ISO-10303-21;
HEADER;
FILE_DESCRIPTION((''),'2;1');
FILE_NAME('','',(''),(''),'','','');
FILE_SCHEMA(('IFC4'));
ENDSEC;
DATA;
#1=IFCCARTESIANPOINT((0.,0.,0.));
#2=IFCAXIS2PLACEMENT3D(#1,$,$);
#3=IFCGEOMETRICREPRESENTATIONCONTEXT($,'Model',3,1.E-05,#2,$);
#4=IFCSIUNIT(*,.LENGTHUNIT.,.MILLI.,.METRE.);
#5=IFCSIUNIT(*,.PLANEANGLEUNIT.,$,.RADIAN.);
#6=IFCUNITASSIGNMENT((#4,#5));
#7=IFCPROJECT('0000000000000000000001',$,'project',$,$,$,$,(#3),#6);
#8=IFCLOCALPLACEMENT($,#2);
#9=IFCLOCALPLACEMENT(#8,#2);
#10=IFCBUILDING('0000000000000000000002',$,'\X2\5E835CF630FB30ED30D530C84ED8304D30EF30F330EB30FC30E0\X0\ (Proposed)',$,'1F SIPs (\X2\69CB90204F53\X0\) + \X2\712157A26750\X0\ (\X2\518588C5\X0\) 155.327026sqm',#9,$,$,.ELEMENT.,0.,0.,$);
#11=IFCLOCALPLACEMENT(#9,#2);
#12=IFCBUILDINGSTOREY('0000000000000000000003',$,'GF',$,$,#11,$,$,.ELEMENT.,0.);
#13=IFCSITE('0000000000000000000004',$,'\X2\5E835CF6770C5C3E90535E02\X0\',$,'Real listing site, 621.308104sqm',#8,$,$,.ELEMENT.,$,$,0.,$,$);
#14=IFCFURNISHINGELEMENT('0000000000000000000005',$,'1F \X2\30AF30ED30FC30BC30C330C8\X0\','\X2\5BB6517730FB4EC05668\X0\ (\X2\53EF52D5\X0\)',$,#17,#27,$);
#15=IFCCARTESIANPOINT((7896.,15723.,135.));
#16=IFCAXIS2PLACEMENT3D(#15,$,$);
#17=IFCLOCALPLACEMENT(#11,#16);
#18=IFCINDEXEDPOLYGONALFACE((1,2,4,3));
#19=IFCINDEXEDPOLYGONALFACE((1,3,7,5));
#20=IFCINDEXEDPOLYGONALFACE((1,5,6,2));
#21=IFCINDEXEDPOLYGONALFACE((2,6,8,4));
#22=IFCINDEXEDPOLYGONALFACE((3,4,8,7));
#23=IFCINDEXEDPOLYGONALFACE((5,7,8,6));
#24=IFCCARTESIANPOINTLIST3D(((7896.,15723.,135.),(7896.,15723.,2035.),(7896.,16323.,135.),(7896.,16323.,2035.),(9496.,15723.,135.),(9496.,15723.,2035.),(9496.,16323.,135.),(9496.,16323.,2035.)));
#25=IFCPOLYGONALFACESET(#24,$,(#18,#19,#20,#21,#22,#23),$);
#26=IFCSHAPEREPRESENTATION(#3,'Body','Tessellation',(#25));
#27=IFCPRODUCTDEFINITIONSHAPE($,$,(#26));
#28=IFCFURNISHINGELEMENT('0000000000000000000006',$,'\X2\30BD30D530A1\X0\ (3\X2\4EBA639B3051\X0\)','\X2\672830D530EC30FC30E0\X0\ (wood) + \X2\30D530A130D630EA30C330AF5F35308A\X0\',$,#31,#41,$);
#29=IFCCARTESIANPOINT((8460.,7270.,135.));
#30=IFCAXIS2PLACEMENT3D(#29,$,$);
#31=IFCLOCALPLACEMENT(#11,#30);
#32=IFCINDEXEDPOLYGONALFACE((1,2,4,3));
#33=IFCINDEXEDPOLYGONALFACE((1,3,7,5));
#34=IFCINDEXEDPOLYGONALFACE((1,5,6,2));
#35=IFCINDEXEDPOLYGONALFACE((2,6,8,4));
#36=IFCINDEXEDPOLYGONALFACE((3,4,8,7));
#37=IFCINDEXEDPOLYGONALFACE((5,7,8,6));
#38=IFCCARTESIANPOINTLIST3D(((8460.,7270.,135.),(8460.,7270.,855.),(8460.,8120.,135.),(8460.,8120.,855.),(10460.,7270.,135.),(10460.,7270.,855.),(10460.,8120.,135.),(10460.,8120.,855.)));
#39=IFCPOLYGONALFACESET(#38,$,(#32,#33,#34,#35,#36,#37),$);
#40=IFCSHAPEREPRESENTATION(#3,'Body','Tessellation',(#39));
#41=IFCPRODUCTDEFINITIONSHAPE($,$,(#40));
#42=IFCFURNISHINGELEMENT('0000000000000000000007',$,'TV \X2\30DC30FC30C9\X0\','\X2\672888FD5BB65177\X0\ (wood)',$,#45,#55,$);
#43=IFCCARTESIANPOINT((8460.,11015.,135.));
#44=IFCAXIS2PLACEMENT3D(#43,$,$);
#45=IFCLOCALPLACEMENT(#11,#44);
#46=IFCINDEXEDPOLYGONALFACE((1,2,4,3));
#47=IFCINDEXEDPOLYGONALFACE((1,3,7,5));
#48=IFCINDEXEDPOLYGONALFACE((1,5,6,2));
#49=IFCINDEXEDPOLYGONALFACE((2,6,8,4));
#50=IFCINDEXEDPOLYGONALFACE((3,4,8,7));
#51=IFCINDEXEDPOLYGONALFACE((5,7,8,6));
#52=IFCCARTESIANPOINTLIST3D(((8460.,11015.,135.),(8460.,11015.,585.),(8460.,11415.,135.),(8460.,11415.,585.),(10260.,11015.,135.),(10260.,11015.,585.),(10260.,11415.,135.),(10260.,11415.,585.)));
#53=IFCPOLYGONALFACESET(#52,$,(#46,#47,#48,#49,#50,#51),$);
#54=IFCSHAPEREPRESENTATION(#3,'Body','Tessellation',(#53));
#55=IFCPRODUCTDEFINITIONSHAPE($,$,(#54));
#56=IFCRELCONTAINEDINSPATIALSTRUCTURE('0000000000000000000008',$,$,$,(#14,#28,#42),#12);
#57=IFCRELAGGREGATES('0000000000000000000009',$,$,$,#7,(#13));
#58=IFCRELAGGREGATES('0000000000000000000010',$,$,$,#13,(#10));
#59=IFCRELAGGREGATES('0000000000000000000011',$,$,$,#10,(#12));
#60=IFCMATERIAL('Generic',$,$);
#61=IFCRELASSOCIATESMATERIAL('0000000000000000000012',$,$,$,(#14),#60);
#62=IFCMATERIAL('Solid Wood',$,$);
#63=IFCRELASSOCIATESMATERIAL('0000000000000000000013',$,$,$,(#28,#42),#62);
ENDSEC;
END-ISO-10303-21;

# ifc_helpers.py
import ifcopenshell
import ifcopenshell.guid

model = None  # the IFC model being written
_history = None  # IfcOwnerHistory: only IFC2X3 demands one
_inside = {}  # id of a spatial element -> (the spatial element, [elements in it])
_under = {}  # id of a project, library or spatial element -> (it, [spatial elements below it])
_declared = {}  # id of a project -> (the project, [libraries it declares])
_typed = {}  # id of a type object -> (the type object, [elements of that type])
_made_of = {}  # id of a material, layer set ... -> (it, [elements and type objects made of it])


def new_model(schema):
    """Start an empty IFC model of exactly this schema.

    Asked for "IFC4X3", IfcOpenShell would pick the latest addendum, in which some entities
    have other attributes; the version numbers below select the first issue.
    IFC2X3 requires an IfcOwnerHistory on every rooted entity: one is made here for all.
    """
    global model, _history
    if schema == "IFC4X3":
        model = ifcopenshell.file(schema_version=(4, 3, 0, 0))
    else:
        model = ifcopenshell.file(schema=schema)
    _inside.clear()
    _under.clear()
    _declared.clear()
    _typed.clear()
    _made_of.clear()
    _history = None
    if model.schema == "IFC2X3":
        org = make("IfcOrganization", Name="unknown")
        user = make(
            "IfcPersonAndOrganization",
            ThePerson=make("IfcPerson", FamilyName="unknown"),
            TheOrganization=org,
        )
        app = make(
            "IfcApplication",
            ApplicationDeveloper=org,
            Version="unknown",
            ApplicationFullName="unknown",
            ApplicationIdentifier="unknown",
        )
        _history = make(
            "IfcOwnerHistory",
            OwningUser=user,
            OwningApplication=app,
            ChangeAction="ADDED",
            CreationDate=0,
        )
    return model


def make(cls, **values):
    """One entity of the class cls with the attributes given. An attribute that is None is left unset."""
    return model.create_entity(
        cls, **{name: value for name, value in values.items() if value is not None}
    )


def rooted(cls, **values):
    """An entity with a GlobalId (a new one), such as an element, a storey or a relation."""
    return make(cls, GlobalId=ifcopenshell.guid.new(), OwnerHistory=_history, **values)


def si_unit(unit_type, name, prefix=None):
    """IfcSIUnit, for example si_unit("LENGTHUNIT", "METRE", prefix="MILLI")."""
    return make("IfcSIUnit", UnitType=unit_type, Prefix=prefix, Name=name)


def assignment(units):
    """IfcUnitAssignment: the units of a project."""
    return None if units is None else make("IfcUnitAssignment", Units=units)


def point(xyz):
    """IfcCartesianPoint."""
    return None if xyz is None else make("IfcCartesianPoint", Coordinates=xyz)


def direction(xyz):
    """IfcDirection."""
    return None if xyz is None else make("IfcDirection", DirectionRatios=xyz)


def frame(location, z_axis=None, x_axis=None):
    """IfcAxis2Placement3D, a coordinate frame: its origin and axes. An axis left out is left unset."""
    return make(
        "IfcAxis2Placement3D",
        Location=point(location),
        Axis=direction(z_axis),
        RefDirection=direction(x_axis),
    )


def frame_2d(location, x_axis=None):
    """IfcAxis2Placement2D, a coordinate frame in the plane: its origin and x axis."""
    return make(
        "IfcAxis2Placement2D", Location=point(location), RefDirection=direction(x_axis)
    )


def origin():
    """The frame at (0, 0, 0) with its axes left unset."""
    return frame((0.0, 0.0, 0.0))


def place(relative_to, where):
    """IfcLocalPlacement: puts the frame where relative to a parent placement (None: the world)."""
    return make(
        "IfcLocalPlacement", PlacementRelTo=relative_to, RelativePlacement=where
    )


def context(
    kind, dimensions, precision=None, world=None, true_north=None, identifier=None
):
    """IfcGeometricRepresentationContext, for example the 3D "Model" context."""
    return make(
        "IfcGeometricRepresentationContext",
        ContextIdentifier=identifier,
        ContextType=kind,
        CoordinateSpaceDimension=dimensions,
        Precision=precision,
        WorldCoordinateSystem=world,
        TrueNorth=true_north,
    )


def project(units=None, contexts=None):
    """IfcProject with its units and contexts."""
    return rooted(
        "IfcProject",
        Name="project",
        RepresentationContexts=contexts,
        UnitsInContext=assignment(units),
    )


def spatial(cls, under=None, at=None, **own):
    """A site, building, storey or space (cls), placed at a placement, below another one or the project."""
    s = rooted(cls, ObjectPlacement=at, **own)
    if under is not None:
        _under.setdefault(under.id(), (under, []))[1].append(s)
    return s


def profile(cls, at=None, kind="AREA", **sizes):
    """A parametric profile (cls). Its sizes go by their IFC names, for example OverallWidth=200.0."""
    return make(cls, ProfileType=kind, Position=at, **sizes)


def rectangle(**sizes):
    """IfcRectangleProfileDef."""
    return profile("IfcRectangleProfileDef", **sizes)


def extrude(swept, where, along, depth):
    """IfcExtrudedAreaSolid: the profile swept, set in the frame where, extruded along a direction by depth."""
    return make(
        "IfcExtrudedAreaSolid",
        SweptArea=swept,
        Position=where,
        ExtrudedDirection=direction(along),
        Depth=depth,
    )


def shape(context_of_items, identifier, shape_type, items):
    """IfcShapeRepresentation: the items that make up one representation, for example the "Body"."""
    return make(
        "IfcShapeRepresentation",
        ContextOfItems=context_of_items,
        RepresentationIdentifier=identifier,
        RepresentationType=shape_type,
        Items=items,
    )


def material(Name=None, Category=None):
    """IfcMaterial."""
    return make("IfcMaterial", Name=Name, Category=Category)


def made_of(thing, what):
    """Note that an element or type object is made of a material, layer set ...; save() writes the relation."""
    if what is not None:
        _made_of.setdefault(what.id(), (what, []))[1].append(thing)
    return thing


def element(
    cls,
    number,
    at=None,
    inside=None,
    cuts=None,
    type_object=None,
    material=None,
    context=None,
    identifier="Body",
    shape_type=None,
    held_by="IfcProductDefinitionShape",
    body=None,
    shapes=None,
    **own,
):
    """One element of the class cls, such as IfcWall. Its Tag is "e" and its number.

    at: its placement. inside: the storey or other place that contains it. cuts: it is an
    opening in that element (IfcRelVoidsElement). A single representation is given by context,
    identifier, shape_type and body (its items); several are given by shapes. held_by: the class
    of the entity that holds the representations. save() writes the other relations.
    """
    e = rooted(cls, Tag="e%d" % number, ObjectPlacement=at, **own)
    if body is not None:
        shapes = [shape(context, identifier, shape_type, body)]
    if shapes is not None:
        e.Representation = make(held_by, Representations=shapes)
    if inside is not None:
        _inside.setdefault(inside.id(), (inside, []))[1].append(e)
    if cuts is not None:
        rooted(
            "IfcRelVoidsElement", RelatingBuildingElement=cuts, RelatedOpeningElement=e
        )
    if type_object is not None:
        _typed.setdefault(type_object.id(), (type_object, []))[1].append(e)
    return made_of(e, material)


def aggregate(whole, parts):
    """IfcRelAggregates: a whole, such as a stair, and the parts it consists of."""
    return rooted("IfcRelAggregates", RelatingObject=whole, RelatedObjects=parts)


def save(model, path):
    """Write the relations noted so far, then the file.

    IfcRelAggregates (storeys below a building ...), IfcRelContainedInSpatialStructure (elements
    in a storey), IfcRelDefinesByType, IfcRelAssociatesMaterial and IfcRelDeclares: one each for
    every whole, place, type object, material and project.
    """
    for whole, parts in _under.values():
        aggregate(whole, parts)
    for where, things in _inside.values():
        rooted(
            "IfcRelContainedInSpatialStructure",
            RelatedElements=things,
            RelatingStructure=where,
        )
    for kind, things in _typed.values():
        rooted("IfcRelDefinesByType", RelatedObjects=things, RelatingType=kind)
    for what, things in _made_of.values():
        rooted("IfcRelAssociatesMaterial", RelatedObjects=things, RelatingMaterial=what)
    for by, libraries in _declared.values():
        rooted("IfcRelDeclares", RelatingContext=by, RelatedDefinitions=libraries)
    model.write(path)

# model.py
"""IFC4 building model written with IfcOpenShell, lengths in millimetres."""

from ifc_helpers import new_model, si_unit, frame, frame_2d, origin, place, context, project, spatial, rectangle, extrude, material, element, save


model = new_model("IFC4")

# Units and contexts
model_context = context("Model", 3, precision=1e-05, world=origin())
ifc_project = project(units=[si_unit("LENGTHUNIT", "METRE", prefix="MILLI"), si_unit("PLANEANGLEUNIT", "RADIAN")], contexts=[model_context])

# Site, building, storey
site_placement = place(None, origin())
site = spatial("IfcSite", under=ifc_project, at=site_placement, Name="広島県尾道市", ObjectType="Real listing site, 621.308104sqm", CompositionType="ELEMENT", RefElevation=0.0)
building_placement = place(site_placement, origin())
building = spatial("IfcBuilding", under=site, at=building_placement, Name="広島・ロフト付きワンルーム (Proposed)", ObjectType="1F SIPs (構造体) + 無垢材 (内装) 155.327026sqm", CompositionType="ELEMENT", ElevationOfRefHeight=0.0, ElevationOfTerrain=0.0)
storey_placement = place(building_placement, origin())
storey = spatial("IfcBuildingStorey", under=building, at=storey_placement, Name="GF", CompositionType="ELEMENT", Elevation=0.0)

# Shared definitions
ifc_material_1 = material(Name="Solid Wood")

# Shared definitions
ifc_material_2 = material(Name="Generic")

# Furnishing elements
furnishing_1_placement = place(storey_placement, frame((7896.0, 15723.0, 135.0)))
element("IfcFurnishingElement", 1, at=furnishing_1_placement, inside=storey, material=ifc_material_2, Name="1F クローゼット", Description="家具・什器 (可動)", context=model_context, shape_type="SweptSolid", body=[
    extrude(rectangle(XDim=1600.0, YDim=600.0, at=frame_2d((800.0, 300.0))), frame((7896.0, 15723.0, 135.0)), (0.0, 0.0, 1.0), 1900.0),
])
furnishing_2_placement = place(storey_placement, frame((8460.0, 7270.0, 135.0)))
element("IfcFurnishingElement", 2, at=furnishing_2_placement, inside=storey, material=ifc_material_1, Name="ソファ (3人掛け)", Description="木フレーム (wood) + ファブリック張り", context=model_context, shape_type="SweptSolid", body=[
    extrude(rectangle(XDim=2000.0, YDim=850.0, at=frame_2d((1000.0, 425.0))), frame((8460.0, 7270.0, 135.0)), (0.0, 0.0, 1.0), 720.0),
])
furnishing_3_placement = place(storey_placement, frame((8460.0, 11015.0, 135.0)))
element("IfcFurnishingElement", 3, at=furnishing_3_placement, inside=storey, material=ifc_material_1, Name="TV ボード", Description="木製家具 (wood)", context=model_context, shape_type="SweptSolid", body=[
    extrude(rectangle(XDim=1800.0, YDim=400.0, at=frame_2d((900.0, 200.0))), frame((8460.0, 11015.0, 135.0)), (0.0, 0.0, 1.0), 450.0),
])

save(model, "model.ifc")
